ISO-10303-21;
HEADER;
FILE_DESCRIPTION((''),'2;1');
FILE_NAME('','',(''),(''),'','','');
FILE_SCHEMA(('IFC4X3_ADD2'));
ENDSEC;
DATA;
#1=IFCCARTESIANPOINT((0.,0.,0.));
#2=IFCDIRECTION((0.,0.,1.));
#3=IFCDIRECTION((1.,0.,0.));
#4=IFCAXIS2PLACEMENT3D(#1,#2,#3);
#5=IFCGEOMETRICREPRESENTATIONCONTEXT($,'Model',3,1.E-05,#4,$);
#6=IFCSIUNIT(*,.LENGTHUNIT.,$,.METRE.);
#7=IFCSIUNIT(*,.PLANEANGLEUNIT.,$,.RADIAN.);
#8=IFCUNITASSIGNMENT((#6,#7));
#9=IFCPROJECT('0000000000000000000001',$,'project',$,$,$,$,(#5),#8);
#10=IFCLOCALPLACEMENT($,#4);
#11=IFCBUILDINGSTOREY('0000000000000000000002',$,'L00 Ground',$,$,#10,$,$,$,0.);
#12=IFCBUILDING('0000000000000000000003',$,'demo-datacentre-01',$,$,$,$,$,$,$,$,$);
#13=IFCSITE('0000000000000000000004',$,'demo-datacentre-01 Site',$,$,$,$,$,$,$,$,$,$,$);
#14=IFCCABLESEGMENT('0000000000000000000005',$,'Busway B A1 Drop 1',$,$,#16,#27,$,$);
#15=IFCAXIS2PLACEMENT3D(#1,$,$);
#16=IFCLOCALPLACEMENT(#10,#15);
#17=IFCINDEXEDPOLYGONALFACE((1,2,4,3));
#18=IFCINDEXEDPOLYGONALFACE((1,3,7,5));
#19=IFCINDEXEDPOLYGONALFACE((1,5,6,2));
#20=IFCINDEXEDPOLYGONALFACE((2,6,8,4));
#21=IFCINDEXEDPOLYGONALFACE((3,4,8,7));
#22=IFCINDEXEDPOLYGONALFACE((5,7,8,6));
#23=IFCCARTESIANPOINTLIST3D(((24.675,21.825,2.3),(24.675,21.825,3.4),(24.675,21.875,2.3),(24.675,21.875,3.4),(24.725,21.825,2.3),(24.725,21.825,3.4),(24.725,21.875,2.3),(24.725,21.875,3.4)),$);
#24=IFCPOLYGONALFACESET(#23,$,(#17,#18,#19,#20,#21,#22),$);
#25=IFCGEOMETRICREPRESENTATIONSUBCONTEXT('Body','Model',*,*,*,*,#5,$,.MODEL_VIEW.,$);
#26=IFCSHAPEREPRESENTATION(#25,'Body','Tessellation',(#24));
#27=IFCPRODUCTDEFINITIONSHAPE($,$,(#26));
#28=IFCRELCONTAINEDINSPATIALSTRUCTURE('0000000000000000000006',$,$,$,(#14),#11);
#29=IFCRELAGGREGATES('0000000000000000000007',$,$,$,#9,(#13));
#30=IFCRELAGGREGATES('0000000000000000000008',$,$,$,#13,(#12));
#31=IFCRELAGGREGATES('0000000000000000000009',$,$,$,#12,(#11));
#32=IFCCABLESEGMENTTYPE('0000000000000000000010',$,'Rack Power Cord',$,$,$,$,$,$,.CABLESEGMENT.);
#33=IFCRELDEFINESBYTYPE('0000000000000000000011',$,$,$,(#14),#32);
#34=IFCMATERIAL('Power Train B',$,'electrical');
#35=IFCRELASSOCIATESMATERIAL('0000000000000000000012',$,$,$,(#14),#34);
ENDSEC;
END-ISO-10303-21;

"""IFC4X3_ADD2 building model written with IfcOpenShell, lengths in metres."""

from ifc_helpers import new_model, si_unit, frame, origin_with_axes, place, context, subcontext, project, spatial, rectangle, extrude, material, type_object, element, save


model = new_model("IFC4X3_ADD2")

# Units and contexts
model_context = context("Model", 3, precision=1e-05, world=origin_with_axes())
body_context = subcontext(model_context, "Body", "Model", "MODEL_VIEW")
ifc_project = project(units=[si_unit("LENGTHUNIT", "METRE"), si_unit("PLANEANGLEUNIT", "RADIAN")], contexts=[model_context])

# Site, building, storey
site = spatial("IfcSite", under=ifc_project, Name="demo-datacentre-01 Site")
building = spatial("IfcBuilding", under=site, Name="demo-datacentre-01")
storey_placement = place(None, origin_with_axes())
storey = spatial("IfcBuildingStorey", under=building, at=storey_placement, Name="L00 Ground", Elevation=0.0)

# Shared definitions
ifc_material_1 = material(Name="Power Train B", Category="electrical")

# Cable segment
cable_segment_type_1 = type_object("IfcCableSegmentType", Name="Rack Power Cord", PredefinedType="CABLESEGMENT")
cable_segment_1_placement = place(storey_placement, frame((24.7, 21.85, 3.4), z_axis=(0.0, 0.0, -1.0), x_axis=(1.0, 0.0, 0.0)))
element("IfcCableSegment", 1, at=cable_segment_1_placement, inside=storey, type_object=cable_segment_type_1, material=ifc_material_1, Name="Busway B A1 Drop 1", context=body_context, shape_type="SweptSolid", body=[
    extrude(rectangle(XDim=0.05, YDim=0.05), origin_with_axes(), (0.0, 0.0, 1.0), 1.1),
])

save(model, "model.ifc")
